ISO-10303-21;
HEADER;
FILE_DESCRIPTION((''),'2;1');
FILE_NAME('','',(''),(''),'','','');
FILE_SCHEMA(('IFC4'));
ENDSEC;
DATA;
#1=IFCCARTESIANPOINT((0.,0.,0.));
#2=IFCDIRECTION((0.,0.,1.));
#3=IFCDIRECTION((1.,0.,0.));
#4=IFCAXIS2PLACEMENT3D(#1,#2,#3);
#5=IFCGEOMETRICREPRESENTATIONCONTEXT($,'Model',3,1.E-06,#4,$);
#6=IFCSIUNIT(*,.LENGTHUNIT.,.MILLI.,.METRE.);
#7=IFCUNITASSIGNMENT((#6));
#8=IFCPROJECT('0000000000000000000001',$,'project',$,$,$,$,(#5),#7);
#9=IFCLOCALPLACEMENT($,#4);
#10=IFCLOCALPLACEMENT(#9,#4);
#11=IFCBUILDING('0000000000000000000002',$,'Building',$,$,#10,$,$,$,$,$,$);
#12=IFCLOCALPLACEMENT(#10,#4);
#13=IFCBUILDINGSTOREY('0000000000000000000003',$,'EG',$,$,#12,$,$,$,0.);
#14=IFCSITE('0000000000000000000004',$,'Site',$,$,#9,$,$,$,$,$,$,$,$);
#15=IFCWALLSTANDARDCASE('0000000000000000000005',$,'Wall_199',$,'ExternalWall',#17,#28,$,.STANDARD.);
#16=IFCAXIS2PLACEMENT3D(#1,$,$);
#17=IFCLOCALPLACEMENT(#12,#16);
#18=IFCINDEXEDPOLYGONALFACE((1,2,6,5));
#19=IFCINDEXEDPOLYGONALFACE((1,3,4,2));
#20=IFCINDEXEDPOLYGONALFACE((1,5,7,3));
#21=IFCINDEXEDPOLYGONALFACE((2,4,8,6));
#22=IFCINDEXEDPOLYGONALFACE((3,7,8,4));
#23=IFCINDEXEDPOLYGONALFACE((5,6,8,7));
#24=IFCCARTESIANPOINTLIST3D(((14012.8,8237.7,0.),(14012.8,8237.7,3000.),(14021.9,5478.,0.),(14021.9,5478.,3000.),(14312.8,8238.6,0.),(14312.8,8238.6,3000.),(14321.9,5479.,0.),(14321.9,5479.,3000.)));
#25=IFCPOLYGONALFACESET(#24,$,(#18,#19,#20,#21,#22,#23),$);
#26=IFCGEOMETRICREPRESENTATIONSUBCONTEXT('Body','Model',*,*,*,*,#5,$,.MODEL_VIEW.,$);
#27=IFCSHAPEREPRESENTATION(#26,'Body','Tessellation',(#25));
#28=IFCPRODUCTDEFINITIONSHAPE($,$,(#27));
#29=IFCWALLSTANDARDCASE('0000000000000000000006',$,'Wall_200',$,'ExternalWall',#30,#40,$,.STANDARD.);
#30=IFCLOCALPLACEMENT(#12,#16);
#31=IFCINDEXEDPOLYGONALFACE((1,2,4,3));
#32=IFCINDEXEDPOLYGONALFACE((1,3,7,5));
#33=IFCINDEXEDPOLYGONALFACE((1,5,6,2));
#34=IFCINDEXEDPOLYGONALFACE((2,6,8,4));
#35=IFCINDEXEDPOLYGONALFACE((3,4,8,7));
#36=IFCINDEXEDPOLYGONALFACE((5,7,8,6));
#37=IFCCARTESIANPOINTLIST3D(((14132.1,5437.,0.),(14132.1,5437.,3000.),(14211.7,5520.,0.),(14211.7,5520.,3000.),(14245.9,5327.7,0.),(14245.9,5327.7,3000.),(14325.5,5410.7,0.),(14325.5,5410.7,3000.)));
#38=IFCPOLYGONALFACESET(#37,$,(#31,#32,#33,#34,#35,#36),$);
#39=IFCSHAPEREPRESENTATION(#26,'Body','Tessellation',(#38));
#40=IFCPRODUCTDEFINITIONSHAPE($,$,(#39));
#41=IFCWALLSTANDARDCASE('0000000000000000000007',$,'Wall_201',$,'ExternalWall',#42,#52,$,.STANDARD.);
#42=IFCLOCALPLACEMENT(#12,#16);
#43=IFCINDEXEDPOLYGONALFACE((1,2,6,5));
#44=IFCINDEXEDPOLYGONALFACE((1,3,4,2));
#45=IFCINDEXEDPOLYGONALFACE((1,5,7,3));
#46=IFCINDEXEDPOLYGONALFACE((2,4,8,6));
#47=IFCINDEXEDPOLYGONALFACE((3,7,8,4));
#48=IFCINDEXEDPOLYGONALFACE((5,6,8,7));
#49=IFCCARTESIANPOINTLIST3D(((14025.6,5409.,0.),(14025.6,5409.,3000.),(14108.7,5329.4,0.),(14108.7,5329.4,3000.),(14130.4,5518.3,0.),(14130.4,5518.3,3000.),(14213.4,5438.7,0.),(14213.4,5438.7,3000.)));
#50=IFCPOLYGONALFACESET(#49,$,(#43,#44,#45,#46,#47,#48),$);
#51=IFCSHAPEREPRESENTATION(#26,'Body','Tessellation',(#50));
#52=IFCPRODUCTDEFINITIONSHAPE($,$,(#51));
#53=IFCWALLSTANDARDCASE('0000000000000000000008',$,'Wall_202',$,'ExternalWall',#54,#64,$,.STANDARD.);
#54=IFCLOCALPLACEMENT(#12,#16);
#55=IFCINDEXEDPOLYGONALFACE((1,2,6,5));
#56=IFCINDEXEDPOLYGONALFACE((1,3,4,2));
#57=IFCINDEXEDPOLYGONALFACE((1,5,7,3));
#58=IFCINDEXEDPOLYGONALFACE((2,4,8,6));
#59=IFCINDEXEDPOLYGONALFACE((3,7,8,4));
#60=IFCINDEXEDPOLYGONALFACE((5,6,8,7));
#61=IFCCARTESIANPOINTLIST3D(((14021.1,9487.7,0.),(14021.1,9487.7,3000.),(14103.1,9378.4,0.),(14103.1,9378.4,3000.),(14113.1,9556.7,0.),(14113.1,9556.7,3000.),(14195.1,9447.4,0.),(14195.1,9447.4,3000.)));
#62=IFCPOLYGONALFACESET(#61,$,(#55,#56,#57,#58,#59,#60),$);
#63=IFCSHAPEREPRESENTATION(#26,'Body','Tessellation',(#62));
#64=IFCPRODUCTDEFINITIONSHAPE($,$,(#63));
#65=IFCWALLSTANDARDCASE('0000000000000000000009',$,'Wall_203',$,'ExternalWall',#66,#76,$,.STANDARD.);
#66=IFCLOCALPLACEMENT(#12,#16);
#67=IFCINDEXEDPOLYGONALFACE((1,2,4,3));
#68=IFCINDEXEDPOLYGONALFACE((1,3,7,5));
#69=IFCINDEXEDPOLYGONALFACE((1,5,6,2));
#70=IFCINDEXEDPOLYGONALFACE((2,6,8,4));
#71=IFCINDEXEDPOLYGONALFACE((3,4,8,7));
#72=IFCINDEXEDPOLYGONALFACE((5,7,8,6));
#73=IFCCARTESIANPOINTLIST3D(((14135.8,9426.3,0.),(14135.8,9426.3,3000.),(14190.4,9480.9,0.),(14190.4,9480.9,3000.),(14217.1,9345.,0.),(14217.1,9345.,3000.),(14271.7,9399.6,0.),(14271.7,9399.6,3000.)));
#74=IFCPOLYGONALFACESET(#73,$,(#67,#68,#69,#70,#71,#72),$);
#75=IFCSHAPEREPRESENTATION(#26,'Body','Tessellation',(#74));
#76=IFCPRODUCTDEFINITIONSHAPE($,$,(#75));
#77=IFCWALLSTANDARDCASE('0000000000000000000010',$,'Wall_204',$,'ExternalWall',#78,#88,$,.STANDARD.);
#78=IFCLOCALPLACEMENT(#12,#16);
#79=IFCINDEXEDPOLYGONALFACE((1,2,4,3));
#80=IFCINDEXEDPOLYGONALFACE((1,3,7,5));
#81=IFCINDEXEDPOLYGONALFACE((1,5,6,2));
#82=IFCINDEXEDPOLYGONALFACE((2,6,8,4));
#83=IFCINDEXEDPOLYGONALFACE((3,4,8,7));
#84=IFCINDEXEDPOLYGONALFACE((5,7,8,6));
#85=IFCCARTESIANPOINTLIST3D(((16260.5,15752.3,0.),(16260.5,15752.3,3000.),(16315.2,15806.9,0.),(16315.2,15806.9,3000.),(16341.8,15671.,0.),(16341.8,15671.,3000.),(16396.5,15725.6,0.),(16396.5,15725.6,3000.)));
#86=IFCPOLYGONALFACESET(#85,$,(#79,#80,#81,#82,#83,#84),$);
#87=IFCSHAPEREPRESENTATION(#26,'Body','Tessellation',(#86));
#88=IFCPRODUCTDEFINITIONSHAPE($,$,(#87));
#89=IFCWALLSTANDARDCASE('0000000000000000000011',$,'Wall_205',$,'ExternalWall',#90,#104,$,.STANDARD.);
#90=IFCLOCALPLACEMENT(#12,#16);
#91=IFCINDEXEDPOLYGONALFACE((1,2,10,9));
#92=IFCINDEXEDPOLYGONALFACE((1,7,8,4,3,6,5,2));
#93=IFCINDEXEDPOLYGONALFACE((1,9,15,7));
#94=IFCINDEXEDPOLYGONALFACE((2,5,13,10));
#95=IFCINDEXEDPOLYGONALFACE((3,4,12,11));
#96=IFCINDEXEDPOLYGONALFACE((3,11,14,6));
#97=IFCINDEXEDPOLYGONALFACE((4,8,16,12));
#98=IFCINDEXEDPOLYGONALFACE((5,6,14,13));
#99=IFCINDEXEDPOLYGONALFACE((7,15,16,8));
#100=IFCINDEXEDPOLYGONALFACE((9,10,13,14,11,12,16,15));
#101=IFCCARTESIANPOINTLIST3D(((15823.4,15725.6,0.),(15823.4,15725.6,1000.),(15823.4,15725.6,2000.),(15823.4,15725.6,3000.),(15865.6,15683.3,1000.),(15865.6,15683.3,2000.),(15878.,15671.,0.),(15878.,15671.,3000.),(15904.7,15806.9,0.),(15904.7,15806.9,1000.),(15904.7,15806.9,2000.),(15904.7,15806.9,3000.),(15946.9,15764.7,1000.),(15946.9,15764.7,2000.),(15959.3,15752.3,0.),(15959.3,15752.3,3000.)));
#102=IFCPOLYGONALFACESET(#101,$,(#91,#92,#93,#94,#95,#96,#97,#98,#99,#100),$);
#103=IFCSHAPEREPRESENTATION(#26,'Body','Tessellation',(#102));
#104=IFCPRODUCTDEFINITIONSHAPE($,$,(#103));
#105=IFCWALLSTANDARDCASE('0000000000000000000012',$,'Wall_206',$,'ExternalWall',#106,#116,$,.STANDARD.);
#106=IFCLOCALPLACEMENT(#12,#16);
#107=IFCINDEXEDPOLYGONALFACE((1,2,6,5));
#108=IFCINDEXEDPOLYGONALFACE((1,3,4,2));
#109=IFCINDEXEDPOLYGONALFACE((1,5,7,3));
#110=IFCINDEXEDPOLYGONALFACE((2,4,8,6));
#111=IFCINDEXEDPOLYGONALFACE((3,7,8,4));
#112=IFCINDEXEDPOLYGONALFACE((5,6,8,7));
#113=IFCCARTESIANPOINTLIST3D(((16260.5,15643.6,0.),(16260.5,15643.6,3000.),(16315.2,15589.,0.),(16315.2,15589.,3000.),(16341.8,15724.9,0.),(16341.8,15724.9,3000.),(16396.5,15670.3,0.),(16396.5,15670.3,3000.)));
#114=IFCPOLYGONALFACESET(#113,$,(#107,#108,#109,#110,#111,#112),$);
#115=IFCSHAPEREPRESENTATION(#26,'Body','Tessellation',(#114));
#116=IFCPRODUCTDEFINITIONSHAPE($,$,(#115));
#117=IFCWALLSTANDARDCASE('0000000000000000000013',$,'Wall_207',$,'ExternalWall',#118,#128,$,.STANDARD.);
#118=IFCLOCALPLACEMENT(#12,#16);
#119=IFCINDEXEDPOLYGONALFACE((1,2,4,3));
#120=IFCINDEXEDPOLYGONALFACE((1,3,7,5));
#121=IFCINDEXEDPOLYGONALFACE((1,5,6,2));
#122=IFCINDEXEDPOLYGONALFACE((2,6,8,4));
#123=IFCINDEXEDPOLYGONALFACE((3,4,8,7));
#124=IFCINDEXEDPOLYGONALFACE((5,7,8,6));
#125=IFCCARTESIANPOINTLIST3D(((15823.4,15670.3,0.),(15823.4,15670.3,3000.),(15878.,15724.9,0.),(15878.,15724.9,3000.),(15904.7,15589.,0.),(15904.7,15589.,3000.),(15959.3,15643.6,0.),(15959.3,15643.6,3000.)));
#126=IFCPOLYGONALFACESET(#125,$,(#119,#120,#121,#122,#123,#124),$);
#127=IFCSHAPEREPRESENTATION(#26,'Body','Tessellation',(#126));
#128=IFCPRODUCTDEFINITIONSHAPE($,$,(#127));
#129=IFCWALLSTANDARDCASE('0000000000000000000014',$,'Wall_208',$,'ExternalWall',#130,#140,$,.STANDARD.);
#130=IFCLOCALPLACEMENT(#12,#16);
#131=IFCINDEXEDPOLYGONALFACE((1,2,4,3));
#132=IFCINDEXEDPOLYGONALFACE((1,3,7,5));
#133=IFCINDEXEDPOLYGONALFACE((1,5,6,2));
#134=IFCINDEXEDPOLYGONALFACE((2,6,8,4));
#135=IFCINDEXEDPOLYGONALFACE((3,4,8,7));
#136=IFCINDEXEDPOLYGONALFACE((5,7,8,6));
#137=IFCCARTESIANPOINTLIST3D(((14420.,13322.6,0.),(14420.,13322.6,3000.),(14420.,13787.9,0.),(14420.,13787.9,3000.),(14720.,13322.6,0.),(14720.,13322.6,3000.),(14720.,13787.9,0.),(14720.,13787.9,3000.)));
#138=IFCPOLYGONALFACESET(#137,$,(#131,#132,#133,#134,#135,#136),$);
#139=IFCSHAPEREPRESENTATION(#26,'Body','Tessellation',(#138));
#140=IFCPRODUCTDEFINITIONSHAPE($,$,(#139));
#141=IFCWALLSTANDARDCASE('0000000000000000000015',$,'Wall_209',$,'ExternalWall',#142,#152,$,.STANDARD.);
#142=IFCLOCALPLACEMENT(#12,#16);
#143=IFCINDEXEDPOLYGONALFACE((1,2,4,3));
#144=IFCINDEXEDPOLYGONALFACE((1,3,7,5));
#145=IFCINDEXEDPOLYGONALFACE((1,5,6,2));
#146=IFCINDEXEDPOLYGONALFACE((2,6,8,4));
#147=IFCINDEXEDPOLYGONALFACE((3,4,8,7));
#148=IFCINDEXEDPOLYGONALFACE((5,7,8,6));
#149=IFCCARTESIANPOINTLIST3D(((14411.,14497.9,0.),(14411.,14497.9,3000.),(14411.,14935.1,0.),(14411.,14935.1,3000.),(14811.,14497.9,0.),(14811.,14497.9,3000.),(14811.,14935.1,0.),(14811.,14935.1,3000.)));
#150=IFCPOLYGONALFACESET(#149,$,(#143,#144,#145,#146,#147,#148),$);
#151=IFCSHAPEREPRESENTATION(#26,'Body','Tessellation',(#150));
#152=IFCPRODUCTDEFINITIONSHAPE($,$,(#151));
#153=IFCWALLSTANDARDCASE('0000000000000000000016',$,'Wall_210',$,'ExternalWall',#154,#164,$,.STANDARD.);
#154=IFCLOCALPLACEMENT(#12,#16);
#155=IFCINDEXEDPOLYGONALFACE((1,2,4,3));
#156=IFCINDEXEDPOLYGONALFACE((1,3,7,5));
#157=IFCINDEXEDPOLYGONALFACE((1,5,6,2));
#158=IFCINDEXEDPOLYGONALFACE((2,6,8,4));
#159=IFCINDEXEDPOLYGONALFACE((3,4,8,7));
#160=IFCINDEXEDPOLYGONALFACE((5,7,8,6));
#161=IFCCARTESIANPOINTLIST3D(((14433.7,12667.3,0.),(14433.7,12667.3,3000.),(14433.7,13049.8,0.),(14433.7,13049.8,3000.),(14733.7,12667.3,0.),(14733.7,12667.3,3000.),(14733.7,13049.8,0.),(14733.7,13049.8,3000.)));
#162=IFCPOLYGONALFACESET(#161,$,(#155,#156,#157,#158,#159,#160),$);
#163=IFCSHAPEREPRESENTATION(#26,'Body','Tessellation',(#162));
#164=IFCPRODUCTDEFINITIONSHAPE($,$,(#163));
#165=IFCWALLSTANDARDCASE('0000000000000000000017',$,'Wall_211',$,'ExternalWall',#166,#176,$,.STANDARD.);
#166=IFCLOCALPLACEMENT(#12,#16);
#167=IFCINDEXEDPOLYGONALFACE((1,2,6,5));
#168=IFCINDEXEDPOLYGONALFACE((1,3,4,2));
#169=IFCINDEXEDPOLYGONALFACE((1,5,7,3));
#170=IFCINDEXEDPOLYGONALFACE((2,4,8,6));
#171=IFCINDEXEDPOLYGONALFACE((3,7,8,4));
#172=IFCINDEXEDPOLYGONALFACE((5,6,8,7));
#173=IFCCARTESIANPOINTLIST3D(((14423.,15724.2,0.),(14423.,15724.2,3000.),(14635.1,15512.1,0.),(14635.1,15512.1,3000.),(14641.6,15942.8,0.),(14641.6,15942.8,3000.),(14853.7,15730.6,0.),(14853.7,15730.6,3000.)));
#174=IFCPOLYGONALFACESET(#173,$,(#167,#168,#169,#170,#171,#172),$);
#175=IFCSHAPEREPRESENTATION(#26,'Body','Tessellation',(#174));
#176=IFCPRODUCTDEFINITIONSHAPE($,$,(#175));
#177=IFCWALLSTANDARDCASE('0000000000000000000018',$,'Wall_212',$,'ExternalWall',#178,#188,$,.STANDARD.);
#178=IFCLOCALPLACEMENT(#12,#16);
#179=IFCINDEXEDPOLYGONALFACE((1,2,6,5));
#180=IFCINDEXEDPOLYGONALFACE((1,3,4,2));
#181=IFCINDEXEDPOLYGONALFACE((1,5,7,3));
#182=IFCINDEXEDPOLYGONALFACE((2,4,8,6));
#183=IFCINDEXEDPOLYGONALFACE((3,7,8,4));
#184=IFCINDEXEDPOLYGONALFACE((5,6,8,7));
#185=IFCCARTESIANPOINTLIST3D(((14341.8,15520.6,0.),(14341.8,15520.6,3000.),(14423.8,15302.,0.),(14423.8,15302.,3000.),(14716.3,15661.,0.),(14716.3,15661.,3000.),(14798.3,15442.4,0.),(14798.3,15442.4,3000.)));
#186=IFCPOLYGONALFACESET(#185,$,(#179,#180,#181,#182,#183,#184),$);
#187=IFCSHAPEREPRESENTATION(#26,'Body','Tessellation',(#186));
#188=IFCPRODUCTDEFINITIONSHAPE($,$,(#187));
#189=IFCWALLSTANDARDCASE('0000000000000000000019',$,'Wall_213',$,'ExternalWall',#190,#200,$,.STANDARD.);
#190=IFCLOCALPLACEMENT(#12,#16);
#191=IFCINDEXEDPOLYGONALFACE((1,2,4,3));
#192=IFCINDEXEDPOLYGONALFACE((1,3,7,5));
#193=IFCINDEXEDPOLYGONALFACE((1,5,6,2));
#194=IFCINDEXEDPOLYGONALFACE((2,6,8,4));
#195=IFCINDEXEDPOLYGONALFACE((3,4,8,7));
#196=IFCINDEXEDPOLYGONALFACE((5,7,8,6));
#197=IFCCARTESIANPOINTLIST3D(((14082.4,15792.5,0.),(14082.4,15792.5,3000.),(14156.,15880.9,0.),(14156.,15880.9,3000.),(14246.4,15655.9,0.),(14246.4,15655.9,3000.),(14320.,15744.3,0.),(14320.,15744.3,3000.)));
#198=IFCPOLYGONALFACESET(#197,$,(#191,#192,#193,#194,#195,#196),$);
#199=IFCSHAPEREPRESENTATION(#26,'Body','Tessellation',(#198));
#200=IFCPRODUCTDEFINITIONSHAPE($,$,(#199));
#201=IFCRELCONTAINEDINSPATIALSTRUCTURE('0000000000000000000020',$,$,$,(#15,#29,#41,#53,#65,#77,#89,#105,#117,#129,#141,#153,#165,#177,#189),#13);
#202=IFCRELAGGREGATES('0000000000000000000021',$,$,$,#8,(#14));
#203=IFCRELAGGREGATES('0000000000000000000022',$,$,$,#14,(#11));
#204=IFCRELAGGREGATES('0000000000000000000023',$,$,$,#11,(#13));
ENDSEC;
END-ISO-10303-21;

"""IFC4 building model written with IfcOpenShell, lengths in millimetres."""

from ifc_helpers import new_model, si_unit, frame, origin_with_axes, place, context, subcontext, project, spatial, rectangle, extrude, element, save


model = new_model("IFC4")

# Units and contexts
model_context = context("Model", 3, precision=1e-06, world=origin_with_axes())
body_context = subcontext(model_context, "Body", "Model", "MODEL_VIEW")
ifc_project = project(units=[si_unit("LENGTHUNIT", "METRE", prefix="MILLI")], contexts=[model_context])

# Site, building, storey
site_placement = place(None, origin_with_axes())
site = spatial("IfcSite", under=ifc_project, at=site_placement, Name="Site")
building_placement = place(site_placement, origin_with_axes())
building = spatial("IfcBuilding", under=site, at=building_placement, Name="Building")
storey_placement = place(building_placement, origin_with_axes())
storey = spatial("IfcBuildingStorey", under=building, at=storey_placement, Name="EG", Elevation=0.0)

# Walls
wall_1_placement = place(storey_placement, origin_with_axes())
element("IfcWallStandardCase", 1, at=wall_1_placement, inside=storey, Name="Wall_199", ObjectType="ExternalWall", PredefinedType="STANDARD", context=body_context, shape_type="SweptSolid", body=[
    extrude(rectangle(XDim=2759.7, YDim=300.0), frame((14167.3, 6858.3, 0.0), z_axis=(0.0, 0.0, 1.0), x_axis=(0.0033, -0.999995, 0.0)), (0.0, 0.0, 1.0), 3000.0),
])
wall_2_placement = place(storey_placement, origin_with_axes())
element("IfcWallStandardCase", 2, at=wall_2_placement, inside=storey, Name="Wall_200", ObjectType="ExternalWall", PredefinedType="STANDARD", context=body_context, shape_type="SweptSolid", body=[
    extrude(rectangle(XDim=157.8, YDim=115.0), frame((14228.8, 5423.9, 0.0), z_axis=(0.0, 0.0, 1.0), x_axis=(0.721459, -0.692457, 0.0)), (0.0, 0.0, 1.0), 3000.0),
])
wall_3_placement = place(storey_placement, origin_with_axes())
element("IfcWallStandardCase", 3, at=wall_3_placement, inside=storey, Name="Wall_201", ObjectType="ExternalWall", PredefinedType="STANDARD", context=body_context, shape_type="SweptSolid", body=[
    extrude(rectangle(XDim=151.4, YDim=115.0), frame((14119.5, 5423.9, 0.0), z_axis=(0.0, 0.0, 1.0), x_axis=(-0.69198, -0.721917, 0.0)), (0.0, 0.0, 1.0), 3000.0),
])
wall_4_placement = place(storey_placement, origin_with_axes())
element("IfcWallStandardCase", 4, at=wall_4_placement, inside=storey, Name="Wall_202", ObjectType="ExternalWall", PredefinedType="STANDARD", context=body_context, shape_type="SweptSolid", body=[
    extrude(rectangle(XDim=136.6, YDim=115.0), frame((14108.1, 9467.6, 0.0), z_axis=(0.0, 0.0, 1.0), x_axis=(-0.6, 0.8, 0.0)), (0.0, 0.0, 1.0), 3000.0),
])
wall_5_placement = place(storey_placement, origin_with_axes())
element("IfcWallStandardCase", 5, at=wall_5_placement, inside=storey, Name="Wall_203", ObjectType="ExternalWall", PredefinedType="STANDARD", context=body_context, shape_type="SweptSolid", body=[
    extrude(rectangle(XDim=77.3, YDim=115.0), frame((14203.8, 9412.9, 0.0), z_axis=(0.0, 0.0, 1.0), x_axis=(0.707107, 0.707107, 0.0)), (0.0, 0.0, 1.0), 3000.0),
])
wall_6_placement = place(storey_placement, origin_with_axes())
element("IfcWallStandardCase", 6, at=wall_6_placement, inside=storey, Name="Wall_204", ObjectType="ExternalWall", PredefinedType="STANDARD", context=body_context, shape_type="SweptSolid", body=[
    extrude(rectangle(XDim=77.3, YDim=115.0), frame((16328.5, 15738.9, 0.0), z_axis=(0.0, 0.0, 1.0), x_axis=(-0.707107, -0.707107, 0.0)), (0.0, 0.0, 1.0), 3000.0),
])

# Wall, opening
wall_7_placement = place(storey_placement, origin_with_axes())
wall_7 = element("IfcWallStandardCase", 7, at=wall_7_placement, inside=storey, Name="Wall_205", ObjectType="ExternalWall", PredefinedType="STANDARD", context=body_context, shape_type="SweptSolid", body=[
    extrude(rectangle(XDim=77.3, YDim=115.0), frame((15891.3, 15738.9, 0.0), z_axis=(0.0, 0.0, 1.0), x_axis=(-0.707107, 0.707107, 0.0)), (0.0, 0.0, 1.0), 3000.0),
])
opening_placement = place(wall_7_placement, origin_with_axes())
element("IfcOpeningElement", 8, at=opening_placement, inside=storey, cuts=wall_7, context=body_context, shape_type="SweptSolid", body=[
    extrude(rectangle(XDim=828.6, YDim=115.0), frame((15613.3, 16017.0, 1000.0), z_axis=(0.0, 0.0, 1.0), x_axis=(-0.707107, 0.707107, 0.0)), (0.0, 0.0, 1.0), 1000.0),
])

# Walls
wall_8_placement = place(storey_placement, origin_with_axes())
element("IfcWallStandardCase", 9, at=wall_8_placement, inside=storey, Name="Wall_206", ObjectType="ExternalWall", PredefinedType="STANDARD", context=body_context, shape_type="SweptSolid", body=[
    extrude(rectangle(XDim=77.3, YDim=115.0), frame((16328.5, 15657.0, 0.0), z_axis=(0.0, 0.0, 1.0), x_axis=(0.707107, -0.707107, 0.0)), (0.0, 0.0, 1.0), 3000.0),
])
wall_9_placement = place(storey_placement, origin_with_axes())
element("IfcWallStandardCase", 10, at=wall_9_placement, inside=storey, Name="Wall_207", ObjectType="ExternalWall", PredefinedType="STANDARD", context=body_context, shape_type="SweptSolid", body=[
    extrude(rectangle(XDim=77.3, YDim=115.0), frame((15891.3, 15657.0, 0.0), z_axis=(0.0, 0.0, 1.0), x_axis=(-0.707107, -0.707107, 0.0)), (0.0, 0.0, 1.0), 3000.0),
])
wall_10_placement = place(storey_placement, origin_with_axes())
element("IfcWallStandardCase", 11, at=wall_10_placement, inside=storey, Name="Wall_208", ObjectType="ExternalWall", PredefinedType="STANDARD", context=body_context, shape_type="SweptSolid", body=[
    extrude(rectangle(XDim=465.3, YDim=300.0), frame((14570.0, 13555.3, 0.0), z_axis=(0.0, 0.0, 1.0), x_axis=(0.0, 1.0, 0.0)), (0.0, 0.0, 1.0), 3000.0),
])
wall_11_placement = place(storey_placement, origin_with_axes())
element("IfcWallStandardCase", 12, at=wall_11_placement, inside=storey, Name="Wall_209", ObjectType="ExternalWall", PredefinedType="STANDARD", context=body_context, shape_type="SweptSolid", body=[
    extrude(rectangle(XDim=437.2, YDim=400.0), frame((14611.0, 14716.5, 0.0), z_axis=(0.0, 0.0, 1.0), x_axis=(0.0, 1.0, 0.0)), (0.0, 0.0, 1.0), 3000.0),
])
wall_12_placement = place(storey_placement, origin_with_axes())
element("IfcWallStandardCase", 13, at=wall_12_placement, inside=storey, Name="Wall_210", ObjectType="ExternalWall", PredefinedType="STANDARD", context=body_context, shape_type="SweptSolid", body=[
    extrude(rectangle(XDim=382.5, YDim=300.0), frame((14583.7, 12858.6, 0.0), z_axis=(0.0, 0.0, 1.0), x_axis=(0.0, 1.0, 0.0)), (0.0, 0.0, 1.0), 3000.0),
])
wall_13_placement = place(storey_placement, origin_with_axes())
element("IfcWallStandardCase", 14, at=wall_13_placement, inside=storey, Name="Wall_211", ObjectType="ExternalWall", PredefinedType="STANDARD", context=body_context, shape_type="SweptSolid", body=[
    extrude(rectangle(XDim=309.1, YDim=300.0), frame((14638.4, 15727.4, 0.0), z_axis=(0.0, 0.0, 1.0), x_axis=(0.707107, 0.707107, 0.0)), (0.0, 0.0, 1.0), 3000.0),
])
wall_14_placement = place(storey_placement, origin_with_axes())
element("IfcWallStandardCase", 15, at=wall_14_placement, inside=storey, Name="Wall_212", ObjectType="ExternalWall", PredefinedType="STANDARD", context=body_context, shape_type="SweptSolid", body=[
    extrude(rectangle(XDim=233.4, YDim=400.0), frame((14570.0, 15481.5, 0.0), z_axis=(0.0, 0.0, 1.0), x_axis=(-0.351123, 0.936329, 0.0)), (0.0, 0.0, 1.0), 3000.0),
])
wall_15_placement = place(storey_placement, origin_with_axes())
element("IfcWallStandardCase", 16, at=wall_15_placement, inside=storey, Name="Wall_213", ObjectType="ExternalWall", PredefinedType="STANDARD", context=body_context, shape_type="SweptSolid", body=[
    extrude(rectangle(XDim=213.4, YDim=115.0), frame((14201.2, 15768.4, 0.0), z_axis=(0.0, 0.0, 1.0), x_axis=(-0.768221, 0.640184, 0.0)), (0.0, 0.0, 1.0), 3000.0),
])

save(model, "model.ifc")
